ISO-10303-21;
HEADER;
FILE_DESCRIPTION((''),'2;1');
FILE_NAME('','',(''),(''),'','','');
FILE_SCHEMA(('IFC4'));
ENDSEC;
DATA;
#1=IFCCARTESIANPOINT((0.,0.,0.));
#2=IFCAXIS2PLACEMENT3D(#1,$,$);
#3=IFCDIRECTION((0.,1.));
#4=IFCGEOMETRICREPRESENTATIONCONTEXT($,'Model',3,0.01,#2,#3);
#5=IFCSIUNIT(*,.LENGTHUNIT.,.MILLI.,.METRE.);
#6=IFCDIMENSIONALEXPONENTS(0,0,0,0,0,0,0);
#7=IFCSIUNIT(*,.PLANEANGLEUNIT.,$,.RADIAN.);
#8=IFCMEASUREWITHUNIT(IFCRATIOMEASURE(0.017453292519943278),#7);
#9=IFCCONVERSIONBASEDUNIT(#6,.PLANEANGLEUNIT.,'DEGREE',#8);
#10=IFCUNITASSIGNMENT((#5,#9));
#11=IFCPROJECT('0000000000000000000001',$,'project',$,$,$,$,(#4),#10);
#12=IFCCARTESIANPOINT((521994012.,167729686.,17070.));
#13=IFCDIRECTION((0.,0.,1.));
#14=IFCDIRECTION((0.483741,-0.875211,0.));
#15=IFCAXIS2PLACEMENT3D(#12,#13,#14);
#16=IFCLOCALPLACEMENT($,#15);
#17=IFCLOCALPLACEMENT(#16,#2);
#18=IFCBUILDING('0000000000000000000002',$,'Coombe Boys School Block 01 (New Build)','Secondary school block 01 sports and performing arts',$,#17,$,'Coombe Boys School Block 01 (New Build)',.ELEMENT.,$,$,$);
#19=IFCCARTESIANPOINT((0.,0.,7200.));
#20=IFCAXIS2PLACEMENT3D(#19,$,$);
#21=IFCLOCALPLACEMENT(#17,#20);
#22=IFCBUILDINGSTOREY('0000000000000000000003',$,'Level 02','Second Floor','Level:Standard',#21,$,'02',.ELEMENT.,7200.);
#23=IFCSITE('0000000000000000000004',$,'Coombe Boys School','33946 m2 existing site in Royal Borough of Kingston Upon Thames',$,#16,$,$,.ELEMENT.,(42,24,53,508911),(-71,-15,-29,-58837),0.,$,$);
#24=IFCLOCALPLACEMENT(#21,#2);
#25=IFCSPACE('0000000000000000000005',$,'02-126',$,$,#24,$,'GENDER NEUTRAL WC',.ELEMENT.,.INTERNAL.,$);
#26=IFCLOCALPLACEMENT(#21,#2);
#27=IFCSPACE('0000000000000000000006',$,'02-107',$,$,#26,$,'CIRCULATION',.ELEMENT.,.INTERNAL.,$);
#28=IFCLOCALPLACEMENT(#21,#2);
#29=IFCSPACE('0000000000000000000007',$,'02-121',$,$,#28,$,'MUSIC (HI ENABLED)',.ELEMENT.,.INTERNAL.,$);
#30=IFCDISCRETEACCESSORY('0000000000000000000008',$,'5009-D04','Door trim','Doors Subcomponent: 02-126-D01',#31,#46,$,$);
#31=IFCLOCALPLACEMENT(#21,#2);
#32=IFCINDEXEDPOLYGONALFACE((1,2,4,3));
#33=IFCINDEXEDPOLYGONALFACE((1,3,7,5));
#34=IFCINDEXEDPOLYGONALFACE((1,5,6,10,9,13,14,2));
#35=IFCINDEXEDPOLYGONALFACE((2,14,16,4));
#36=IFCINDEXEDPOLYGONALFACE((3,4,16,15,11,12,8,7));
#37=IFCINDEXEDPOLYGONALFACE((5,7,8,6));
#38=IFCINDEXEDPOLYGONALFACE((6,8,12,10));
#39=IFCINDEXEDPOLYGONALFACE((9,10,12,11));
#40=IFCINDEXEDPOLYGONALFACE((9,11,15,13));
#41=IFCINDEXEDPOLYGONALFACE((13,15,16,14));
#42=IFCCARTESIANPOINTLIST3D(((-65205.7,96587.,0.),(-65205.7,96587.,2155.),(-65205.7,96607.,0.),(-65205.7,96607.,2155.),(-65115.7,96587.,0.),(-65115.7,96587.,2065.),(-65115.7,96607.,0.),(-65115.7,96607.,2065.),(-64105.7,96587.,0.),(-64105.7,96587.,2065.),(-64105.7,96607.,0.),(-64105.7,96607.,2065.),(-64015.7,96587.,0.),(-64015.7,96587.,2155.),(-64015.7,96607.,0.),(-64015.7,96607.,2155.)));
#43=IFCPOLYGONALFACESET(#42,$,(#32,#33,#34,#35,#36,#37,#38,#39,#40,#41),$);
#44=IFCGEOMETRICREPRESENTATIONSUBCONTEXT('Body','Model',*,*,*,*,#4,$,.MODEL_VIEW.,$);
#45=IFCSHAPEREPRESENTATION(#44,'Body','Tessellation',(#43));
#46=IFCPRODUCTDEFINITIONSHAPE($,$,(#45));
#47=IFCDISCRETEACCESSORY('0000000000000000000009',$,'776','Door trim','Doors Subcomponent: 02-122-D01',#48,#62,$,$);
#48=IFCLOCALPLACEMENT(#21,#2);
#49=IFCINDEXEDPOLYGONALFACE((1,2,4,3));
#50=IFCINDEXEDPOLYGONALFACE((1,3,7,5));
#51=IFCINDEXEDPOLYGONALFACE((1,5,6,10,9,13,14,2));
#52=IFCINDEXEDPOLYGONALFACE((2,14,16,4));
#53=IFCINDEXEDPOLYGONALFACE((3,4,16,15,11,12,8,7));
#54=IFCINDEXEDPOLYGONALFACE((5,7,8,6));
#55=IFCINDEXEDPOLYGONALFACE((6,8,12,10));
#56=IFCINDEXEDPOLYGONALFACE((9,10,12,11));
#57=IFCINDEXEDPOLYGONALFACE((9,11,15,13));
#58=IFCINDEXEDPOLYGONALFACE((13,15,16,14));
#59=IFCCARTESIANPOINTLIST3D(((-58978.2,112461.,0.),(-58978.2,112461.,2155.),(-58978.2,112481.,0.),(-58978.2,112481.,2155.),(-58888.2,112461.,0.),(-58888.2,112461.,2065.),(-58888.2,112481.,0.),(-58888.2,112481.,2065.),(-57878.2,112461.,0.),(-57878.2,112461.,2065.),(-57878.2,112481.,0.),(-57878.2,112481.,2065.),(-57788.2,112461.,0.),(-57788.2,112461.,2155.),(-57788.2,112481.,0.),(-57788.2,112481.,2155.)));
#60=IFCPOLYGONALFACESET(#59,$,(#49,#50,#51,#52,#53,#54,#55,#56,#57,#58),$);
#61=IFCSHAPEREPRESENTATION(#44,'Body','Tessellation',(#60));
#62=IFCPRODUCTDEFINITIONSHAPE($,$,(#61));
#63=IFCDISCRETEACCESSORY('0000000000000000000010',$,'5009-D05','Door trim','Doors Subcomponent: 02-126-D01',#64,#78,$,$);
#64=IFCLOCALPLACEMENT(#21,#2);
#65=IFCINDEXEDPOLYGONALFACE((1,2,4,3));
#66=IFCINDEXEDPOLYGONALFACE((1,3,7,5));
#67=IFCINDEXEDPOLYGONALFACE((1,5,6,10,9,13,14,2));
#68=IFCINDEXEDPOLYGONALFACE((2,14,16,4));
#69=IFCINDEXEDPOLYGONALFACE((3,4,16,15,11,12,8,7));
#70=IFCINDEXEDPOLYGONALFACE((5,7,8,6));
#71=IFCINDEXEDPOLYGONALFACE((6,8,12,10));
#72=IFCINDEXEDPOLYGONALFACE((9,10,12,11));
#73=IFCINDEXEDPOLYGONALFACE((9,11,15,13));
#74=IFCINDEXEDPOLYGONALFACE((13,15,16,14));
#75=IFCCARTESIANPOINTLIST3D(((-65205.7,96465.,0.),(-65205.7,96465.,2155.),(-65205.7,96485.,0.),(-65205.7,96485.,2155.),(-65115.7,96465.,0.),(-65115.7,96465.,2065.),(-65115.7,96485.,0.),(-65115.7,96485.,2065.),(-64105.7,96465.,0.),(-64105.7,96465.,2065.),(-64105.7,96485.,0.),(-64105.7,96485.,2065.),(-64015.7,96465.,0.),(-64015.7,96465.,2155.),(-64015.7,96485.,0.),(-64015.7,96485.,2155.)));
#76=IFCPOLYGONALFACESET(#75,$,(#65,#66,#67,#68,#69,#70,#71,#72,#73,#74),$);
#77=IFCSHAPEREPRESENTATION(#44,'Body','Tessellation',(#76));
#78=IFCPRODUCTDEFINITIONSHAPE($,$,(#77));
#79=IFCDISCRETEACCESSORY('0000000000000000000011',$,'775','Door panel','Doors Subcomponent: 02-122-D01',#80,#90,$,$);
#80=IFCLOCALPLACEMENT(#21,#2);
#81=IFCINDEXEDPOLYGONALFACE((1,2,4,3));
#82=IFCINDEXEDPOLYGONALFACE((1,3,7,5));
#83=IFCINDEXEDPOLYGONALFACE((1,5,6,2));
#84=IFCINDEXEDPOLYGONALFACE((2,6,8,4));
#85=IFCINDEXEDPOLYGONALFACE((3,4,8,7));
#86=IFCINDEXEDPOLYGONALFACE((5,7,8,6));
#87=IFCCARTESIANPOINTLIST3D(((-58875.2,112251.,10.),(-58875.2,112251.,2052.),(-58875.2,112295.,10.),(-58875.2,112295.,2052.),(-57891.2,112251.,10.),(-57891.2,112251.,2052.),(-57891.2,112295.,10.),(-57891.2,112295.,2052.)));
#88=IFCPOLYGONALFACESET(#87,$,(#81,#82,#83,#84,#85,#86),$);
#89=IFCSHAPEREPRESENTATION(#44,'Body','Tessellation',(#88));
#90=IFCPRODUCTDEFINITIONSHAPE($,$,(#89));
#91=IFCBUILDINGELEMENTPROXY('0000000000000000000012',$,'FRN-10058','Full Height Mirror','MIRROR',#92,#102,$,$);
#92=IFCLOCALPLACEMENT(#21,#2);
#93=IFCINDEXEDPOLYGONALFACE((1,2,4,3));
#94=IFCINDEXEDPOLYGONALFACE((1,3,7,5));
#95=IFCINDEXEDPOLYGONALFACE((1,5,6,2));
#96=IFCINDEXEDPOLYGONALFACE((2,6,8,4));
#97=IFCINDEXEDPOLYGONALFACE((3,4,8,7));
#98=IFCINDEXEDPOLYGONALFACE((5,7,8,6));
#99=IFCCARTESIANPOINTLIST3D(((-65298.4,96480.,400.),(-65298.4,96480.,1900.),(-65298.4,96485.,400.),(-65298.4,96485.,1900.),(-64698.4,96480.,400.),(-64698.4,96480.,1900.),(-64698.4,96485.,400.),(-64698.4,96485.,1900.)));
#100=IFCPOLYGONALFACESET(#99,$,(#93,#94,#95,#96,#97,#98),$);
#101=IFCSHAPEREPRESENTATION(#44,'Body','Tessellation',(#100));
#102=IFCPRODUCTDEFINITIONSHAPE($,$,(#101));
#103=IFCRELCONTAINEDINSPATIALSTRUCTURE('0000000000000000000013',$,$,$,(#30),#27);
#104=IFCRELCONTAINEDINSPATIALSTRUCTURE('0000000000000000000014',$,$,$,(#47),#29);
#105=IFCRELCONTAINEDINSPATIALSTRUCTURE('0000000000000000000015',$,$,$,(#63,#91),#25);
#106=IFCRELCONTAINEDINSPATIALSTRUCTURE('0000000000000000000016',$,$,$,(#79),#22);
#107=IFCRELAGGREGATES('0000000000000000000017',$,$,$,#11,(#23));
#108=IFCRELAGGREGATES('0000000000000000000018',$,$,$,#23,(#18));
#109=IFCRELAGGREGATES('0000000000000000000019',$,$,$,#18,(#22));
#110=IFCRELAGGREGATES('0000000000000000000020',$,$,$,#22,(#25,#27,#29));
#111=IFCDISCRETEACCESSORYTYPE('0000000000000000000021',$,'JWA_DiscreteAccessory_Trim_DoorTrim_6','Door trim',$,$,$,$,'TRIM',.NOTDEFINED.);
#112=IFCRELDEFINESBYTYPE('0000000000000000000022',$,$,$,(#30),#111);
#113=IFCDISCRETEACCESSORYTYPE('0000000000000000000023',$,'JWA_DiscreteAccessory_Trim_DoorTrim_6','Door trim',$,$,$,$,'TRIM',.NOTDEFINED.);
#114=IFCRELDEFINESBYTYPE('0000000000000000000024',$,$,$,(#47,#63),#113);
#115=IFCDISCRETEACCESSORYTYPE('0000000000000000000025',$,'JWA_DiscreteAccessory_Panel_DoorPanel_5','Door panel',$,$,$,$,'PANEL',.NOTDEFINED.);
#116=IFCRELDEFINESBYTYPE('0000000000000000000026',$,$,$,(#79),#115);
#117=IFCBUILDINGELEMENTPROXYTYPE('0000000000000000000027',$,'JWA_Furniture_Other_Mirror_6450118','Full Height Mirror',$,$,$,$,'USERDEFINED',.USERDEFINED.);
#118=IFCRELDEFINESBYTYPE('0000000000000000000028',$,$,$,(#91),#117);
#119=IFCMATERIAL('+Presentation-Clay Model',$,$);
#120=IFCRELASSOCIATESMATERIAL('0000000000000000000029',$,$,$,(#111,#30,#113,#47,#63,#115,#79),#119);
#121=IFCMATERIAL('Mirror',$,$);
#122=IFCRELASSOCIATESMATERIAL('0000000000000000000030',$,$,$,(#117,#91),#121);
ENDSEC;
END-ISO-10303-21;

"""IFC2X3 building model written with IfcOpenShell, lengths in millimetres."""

from ifc_helpers import new_model, entity, si_unit, converted_unit, direction, frame, origin, origin_2d_with_axis, place, context, subcontext, project, spatial, polyline, rectangle, outline, extrude, source, transform, mapped, material, type_object, type_shapes, element, save


model = new_model("IFC2X3")

# Units and contexts
model_context = context("Model", 3, precision=0.01, world=origin(), true_north=direction((0.0, 1.0)))
body_context = subcontext(model_context, "Body", "Model", "MODEL_VIEW")
ifc_project = project(units=[si_unit("LENGTHUNIT", "METRE", prefix="MILLI"), converted_unit("PLANEANGLEUNIT", "DEGREE", entity("IfcRatioMeasure", 0.017453292519943278), si_unit("PLANEANGLEUNIT", "RADIAN"), dimensions=[0, 0, 0, 0, 0, 0, 0])], contexts=[model_context])

# Site, building, storey
site_placement = place(None, frame((521994012.0, 167729686.0, 17070.0), z_axis=(0.0, 0.0, 1.0), x_axis=(0.483741, -0.875211, 0.0)))
site = spatial("IfcSite", under=ifc_project, at=site_placement, Name="Coombe Boys School", Description="33946 m2 existing site in Royal Borough of Kingston Upon Thames", CompositionType="ELEMENT", RefLatitude=(42, 24, 53, 508911), RefLongitude=(-71, -15, -29, -58837), RefElevation=0.0)
building_placement = place(site_placement, origin())
building = spatial("IfcBuilding", under=site, at=building_placement, Name="Coombe Boys School Block 01 (New Build)", Description="Secondary school block 01 sports and performing arts", LongName="Coombe Boys School Block 01 (New Build)", CompositionType="ELEMENT")
storey_placement = place(building_placement, frame((0.0, 0.0, 7200.0)))
storey = spatial("IfcBuildingStorey", under=building, at=storey_placement, Name="Level 02", Description="Second Floor", ObjectType="Level:Standard", LongName="02", CompositionType="ELEMENT", Elevation=7200.0)

# Shared definitions
space_1_placement = place(storey_placement, origin())
space_1 = spatial("IfcSpace", under=storey, at=space_1_placement, Name="02-126", LongName="GENDER NEUTRAL WC", CompositionType="ELEMENT", InteriorOrExteriorSpace="INTERNAL")

# Shared definitions
ifc_material_1 = material(Name="+Presentation-Clay Model")

# Shared definitions
space_2_placement = place(storey_placement, origin())
space_2 = spatial("IfcSpace", under=storey, at=space_2_placement, Name="02-107", LongName="CIRCULATION", CompositionType="ELEMENT", InteriorOrExteriorSpace="INTERNAL")

# Discrete accessory
discrete_accessory_type_1 = type_object("IfcDiscreteAccessoryType", Name="JWA_DiscreteAccessory_Trim_DoorTrim_6", Description="Door trim", ElementType="TRIM", material=ifc_material_1)
shared_shape_1 = source(origin(), body_context, "Body", "SweptSolid", [
    extrude(outline(polyline([(-1055.0, -595.0), (1100.0, -595.0), (1100.0, 595.0), (-1055.0, 595.0), (-1055.0, 505.0), (1010.0, 505.0), (1010.0, -505.0), (-1055.0, -505.0), (-1055.0, -595.0)])), frame((0.0, -20.0, 1055.0), z_axis=(0.0, 1.0, 0.0), x_axis=(0.0, 0.0, 1.0)), (0.0, 0.0, 1.0), 20.0),
])
type_shapes(discrete_accessory_type_1, [shared_shape_1])
discrete_accessory_1_placement = place(space_2_placement, frame((-64610.7, 96587.0, 0.0), z_axis=(0.0, 0.0, 1.0), x_axis=(-1.0, 0.0, 0.0)))
element("IfcDiscreteAccessory", 1, at=discrete_accessory_1_placement, inside=space_2, type_object=discrete_accessory_type_1, material=ifc_material_1, Name="5009-D04", Description="Door trim", ObjectType="Doors Subcomponent: 02-126-D01", context=body_context, shape_type="MappedRepresentation", body=[
    mapped(shared_shape_1, transform((0.0, 0.0, 0.0), scale=1.0)),
])

# Shared definitions
space_3_placement = place(storey_placement, origin())
space_3 = spatial("IfcSpace", under=storey, at=space_3_placement, Name="02-121", LongName="MUSIC (HI ENABLED)", CompositionType="ELEMENT", InteriorOrExteriorSpace="INTERNAL")

# Discrete accessories
discrete_accessory_type_2 = type_object("IfcDiscreteAccessoryType", Name="JWA_DiscreteAccessory_Trim_DoorTrim_6", Description="Door trim", ElementType="TRIM", material=ifc_material_1)
shared_shape_2 = source(origin(), body_context, "Body", "SweptSolid", [
    extrude(outline(polyline([(505.0, -1055.0), (595.0, -1055.0), (595.0, 1100.0), (-595.0, 1100.0), (-595.0, -1055.0), (-505.0, -1055.0), (-505.0, 1010.0), (505.0, 1010.0), (505.0, -1055.0)])), frame((0.0, 0.0, 1055.0), z_axis=(0.0, 1.0, 0.0), x_axis=(-1.0, 0.0, 0.0)), (0.0, 0.0, 1.0), 20.0),
])
type_shapes(discrete_accessory_type_2, [shared_shape_2])
discrete_accessory_2_placement = place(space_3_placement, frame((-58383.2, 112461.0, 0.0)))
element("IfcDiscreteAccessory", 2, at=discrete_accessory_2_placement, inside=space_3, type_object=discrete_accessory_type_2, material=ifc_material_1, Name="776", Description="Door trim", ObjectType="Doors Subcomponent: 02-122-D01", context=body_context, shape_type="MappedRepresentation", body=[
    mapped(shared_shape_2, transform((0.0, 0.0, 0.0), scale=1.0)),
])
discrete_accessory_3_placement = place(space_1_placement, frame((-64610.7, 96485.0, 0.0), z_axis=(0.0, 0.0, 1.0), x_axis=(-1.0, 0.0, 0.0)))
element("IfcDiscreteAccessory", 3, at=discrete_accessory_3_placement, inside=space_1, type_object=discrete_accessory_type_2, material=ifc_material_1, Name="5009-D05", Description="Door trim", ObjectType="Doors Subcomponent: 02-126-D01", context=body_context, shape_type="MappedRepresentation", body=[
    mapped(shared_shape_2, transform((0.0, 0.0, 0.0), scale=1.0)),
])
discrete_accessory_type_3 = type_object("IfcDiscreteAccessoryType", Name="JWA_DiscreteAccessory_Panel_DoorPanel_5", Description="Door panel", ElementType="PANEL", material=ifc_material_1)
shared_shape_3 = source(origin(), body_context, "Body", "SweptSolid", [
    extrude(rectangle(XDim=984.0, YDim=44.0, at=origin_2d_with_axis()), frame((0.0, -22.0, 10.0)), (0.0, 0.0, 1.0), 2042.0),
])
type_shapes(discrete_accessory_type_3, [shared_shape_3])
discrete_accessory_4_placement = place(storey_placement, frame((-58383.2, 112295.0, 0.0)))
element("IfcDiscreteAccessory", 4, at=discrete_accessory_4_placement, inside=storey, type_object=discrete_accessory_type_3, material=ifc_material_1, Name="775", Description="Door panel", ObjectType="Doors Subcomponent: 02-122-D01", context=body_context, shape_type="MappedRepresentation", body=[
    mapped(shared_shape_3, transform((0.0, 0.0, 0.0), scale=1.0)),
])

# Building element proxy
ifc_material_2 = material(Name="Mirror")
building_element_proxy_type = type_object("IfcBuildingElementProxyType", Name="JWA_Furniture_Other_Mirror_6450118", Description="Full Height Mirror", ElementType="USERDEFINED", PredefinedType="USERDEFINED", material=ifc_material_2)
shared_shape_4 = source(origin(), body_context, "Body", "SweptSolid", [
    extrude(rectangle(XDim=5.0, YDim=600.0, at=origin_2d_with_axis()), frame((0.0, -2.5, 0.0), z_axis=(0.0, 0.0, 1.0), x_axis=(0.0, 1.0, 0.0)), (0.0, 0.0, 1.0), 1500.0),
])
type_shapes(building_element_proxy_type, [shared_shape_4])
proxy_placement = place(space_1_placement, frame((-64998.4, 96485.0, 400.0)))
element("IfcBuildingElementProxy", 5, at=proxy_placement, inside=space_1, type_object=building_element_proxy_type, material=ifc_material_2, Name="FRN-10058", Description="Full Height Mirror", ObjectType="MIRROR", context=body_context, shape_type="MappedRepresentation", body=[
    mapped(shared_shape_4, transform((0.0, 0.0, 0.0), scale=1.0)),
])

save(model, "model.ifc")
